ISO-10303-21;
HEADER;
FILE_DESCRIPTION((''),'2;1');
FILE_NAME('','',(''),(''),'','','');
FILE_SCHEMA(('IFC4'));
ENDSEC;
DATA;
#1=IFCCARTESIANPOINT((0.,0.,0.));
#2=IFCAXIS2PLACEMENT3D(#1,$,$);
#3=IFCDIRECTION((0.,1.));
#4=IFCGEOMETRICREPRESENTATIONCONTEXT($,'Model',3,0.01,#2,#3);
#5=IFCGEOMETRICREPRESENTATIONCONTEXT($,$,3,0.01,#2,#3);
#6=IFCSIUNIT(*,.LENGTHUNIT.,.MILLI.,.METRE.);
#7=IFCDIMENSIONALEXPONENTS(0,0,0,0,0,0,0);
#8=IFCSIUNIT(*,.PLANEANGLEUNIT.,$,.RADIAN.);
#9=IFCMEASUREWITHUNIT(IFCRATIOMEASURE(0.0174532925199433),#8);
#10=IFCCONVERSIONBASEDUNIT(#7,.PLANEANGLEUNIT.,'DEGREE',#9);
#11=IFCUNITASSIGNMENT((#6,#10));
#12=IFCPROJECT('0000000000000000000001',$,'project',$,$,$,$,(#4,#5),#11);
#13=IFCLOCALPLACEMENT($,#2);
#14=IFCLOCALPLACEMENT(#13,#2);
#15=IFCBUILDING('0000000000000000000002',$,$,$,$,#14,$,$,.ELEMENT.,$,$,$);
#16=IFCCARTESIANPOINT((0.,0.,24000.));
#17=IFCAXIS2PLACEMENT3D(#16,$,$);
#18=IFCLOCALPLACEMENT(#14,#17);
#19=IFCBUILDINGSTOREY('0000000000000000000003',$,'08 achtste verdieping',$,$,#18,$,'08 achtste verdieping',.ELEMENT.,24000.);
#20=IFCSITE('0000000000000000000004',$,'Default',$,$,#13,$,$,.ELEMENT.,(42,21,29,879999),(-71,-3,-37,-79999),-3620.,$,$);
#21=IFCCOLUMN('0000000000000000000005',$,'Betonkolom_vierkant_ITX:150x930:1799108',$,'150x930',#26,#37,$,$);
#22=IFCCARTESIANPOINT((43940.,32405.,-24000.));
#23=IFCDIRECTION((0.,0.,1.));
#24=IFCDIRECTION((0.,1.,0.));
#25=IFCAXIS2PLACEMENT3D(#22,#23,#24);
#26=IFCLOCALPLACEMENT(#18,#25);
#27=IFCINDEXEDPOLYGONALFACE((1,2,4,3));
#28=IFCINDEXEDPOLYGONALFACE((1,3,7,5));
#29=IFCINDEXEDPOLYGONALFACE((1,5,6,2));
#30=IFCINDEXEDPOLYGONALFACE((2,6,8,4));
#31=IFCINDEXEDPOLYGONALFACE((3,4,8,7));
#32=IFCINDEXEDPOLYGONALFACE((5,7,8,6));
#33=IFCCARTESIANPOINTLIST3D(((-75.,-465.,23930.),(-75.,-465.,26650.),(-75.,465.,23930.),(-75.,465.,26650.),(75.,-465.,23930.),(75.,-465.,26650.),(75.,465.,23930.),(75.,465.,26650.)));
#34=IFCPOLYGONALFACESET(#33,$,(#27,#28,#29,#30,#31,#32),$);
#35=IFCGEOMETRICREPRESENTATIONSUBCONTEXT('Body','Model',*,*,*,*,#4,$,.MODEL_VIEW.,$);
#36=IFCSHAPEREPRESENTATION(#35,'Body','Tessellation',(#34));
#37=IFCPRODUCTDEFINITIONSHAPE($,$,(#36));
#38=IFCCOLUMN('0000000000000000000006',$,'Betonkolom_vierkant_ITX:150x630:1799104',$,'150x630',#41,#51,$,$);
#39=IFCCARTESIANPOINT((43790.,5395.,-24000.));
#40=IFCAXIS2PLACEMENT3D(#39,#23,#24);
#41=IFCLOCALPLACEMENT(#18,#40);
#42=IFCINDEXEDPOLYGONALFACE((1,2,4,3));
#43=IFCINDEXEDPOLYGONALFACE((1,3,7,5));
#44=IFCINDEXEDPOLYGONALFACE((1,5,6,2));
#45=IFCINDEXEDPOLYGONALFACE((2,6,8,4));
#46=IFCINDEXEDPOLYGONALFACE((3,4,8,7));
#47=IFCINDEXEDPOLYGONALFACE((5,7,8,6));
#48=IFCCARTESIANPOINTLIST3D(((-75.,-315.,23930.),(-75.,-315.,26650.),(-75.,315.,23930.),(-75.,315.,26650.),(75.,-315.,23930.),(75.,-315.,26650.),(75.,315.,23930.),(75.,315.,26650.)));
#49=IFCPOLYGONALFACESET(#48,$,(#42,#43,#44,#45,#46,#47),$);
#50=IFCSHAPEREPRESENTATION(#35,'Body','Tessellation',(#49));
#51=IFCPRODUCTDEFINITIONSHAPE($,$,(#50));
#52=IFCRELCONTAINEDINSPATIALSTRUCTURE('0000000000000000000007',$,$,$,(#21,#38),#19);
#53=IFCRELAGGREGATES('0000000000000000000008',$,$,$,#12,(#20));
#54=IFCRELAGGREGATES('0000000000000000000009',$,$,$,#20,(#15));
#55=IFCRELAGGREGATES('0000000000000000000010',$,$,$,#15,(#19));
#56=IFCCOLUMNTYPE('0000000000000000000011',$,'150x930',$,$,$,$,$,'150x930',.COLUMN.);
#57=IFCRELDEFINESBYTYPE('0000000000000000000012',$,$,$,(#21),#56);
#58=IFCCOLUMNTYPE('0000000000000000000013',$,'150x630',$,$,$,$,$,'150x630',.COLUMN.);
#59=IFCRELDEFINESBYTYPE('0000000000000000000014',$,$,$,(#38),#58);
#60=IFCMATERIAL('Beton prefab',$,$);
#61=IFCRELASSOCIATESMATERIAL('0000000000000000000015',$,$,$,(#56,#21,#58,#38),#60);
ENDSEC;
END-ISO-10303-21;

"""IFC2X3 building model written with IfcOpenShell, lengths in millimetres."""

from ifc_helpers import new_model, entity, si_unit, converted_unit, direction, frame, origin, origin_2d_with_axis, place, context, subcontext, project, spatial, rectangle, extrude, source, transform, mapped, material, type_object, type_shapes, element, save


model = new_model("IFC2X3")

# Units and contexts
model_context = context("Model", 3, precision=0.01, world=origin(), true_north=direction((0.0, 1.0)))
context_of_model = context(None, 3, precision=0.01, world=origin(), true_north=direction((0.0, 1.0)))
body_context = subcontext(model_context, "Body", "Model", "MODEL_VIEW")
ifc_project = project(units=[si_unit("LENGTHUNIT", "METRE", prefix="MILLI"), converted_unit("PLANEANGLEUNIT", "DEGREE", entity("IfcRatioMeasure", 0.0174532925199433), si_unit("PLANEANGLEUNIT", "RADIAN"), dimensions=[0, 0, 0, 0, 0, 0, 0])], contexts=[model_context, context_of_model])

# Site, building, storey
site_placement = place(None, origin())
site = spatial("IfcSite", under=ifc_project, at=site_placement, Name="Default", CompositionType="ELEMENT", RefLatitude=(42, 21, 29, 879999), RefLongitude=(-71, -3, -37, -79999), RefElevation=-3620.0)
building_placement = place(site_placement, origin())
building = spatial("IfcBuilding", under=site, at=building_placement, CompositionType="ELEMENT")
storey_placement = place(building_placement, frame((0.0, 0.0, 24000.0)))
storey = spatial("IfcBuildingStorey", under=building, at=storey_placement, Name="08 achtste verdieping", LongName="08 achtste verdieping", CompositionType="ELEMENT", Elevation=24000.0)

# Columns
ifc_material_1 = material(Name="Beton prefab")
column_type_1 = type_object("IfcColumnType", Name="150x930", ElementType="150x930", PredefinedType="COLUMN", material=ifc_material_1)
shared_shape_1 = source(origin(), body_context, "Body", "SweptSolid", [
    extrude(rectangle(XDim=930.0, YDim=150.0, at=origin_2d_with_axis()), frame((0.0, 0.0, 23930.0), z_axis=(0.0, 0.0, 1.0), x_axis=(0.0, -1.0, 0.0)), (0.0, 0.0, 1.0), 2720.0),
])
type_shapes(column_type_1, [shared_shape_1])
column_1_placement = place(storey_placement, frame((43940.0, 32405.0, -24000.0), z_axis=(0.0, 0.0, 1.0), x_axis=(0.0, 1.0, 0.0)))
element("IfcColumn", 1, at=column_1_placement, inside=storey, type_object=column_type_1, material=ifc_material_1, Name="Betonkolom_vierkant_ITX:150x930:1799108", ObjectType="150x930", context=body_context, shape_type="MappedRepresentation", body=[
    mapped(shared_shape_1, transform((0.0, 0.0, 0.0), scale=1.0)),
])
column_type_2 = type_object("IfcColumnType", Name="150x630", ElementType="150x630", PredefinedType="COLUMN", material=ifc_material_1)
shared_shape_2 = source(origin(), body_context, "Body", "SweptSolid", [
    extrude(rectangle(XDim=630.0, YDim=150.0, at=origin_2d_with_axis()), frame((0.0, 0.0, 23930.0), z_axis=(0.0, 0.0, 1.0), x_axis=(0.0, -1.0, 0.0)), (0.0, 0.0, 1.0), 2720.0),
])
type_shapes(column_type_2, [shared_shape_2])
column_2_placement = place(storey_placement, frame((43790.0, 5395.0, -24000.0), z_axis=(0.0, 0.0, 1.0), x_axis=(0.0, 1.0, 0.0)))
element("IfcColumn", 2, at=column_2_placement, inside=storey, type_object=column_type_2, material=ifc_material_1, Name="Betonkolom_vierkant_ITX:150x630:1799104", ObjectType="150x630", context=body_context, shape_type="MappedRepresentation", body=[
    mapped(shared_shape_2, transform((0.0, 0.0, 0.0), scale=1.0)),
])

save(model, "model.ifc")
